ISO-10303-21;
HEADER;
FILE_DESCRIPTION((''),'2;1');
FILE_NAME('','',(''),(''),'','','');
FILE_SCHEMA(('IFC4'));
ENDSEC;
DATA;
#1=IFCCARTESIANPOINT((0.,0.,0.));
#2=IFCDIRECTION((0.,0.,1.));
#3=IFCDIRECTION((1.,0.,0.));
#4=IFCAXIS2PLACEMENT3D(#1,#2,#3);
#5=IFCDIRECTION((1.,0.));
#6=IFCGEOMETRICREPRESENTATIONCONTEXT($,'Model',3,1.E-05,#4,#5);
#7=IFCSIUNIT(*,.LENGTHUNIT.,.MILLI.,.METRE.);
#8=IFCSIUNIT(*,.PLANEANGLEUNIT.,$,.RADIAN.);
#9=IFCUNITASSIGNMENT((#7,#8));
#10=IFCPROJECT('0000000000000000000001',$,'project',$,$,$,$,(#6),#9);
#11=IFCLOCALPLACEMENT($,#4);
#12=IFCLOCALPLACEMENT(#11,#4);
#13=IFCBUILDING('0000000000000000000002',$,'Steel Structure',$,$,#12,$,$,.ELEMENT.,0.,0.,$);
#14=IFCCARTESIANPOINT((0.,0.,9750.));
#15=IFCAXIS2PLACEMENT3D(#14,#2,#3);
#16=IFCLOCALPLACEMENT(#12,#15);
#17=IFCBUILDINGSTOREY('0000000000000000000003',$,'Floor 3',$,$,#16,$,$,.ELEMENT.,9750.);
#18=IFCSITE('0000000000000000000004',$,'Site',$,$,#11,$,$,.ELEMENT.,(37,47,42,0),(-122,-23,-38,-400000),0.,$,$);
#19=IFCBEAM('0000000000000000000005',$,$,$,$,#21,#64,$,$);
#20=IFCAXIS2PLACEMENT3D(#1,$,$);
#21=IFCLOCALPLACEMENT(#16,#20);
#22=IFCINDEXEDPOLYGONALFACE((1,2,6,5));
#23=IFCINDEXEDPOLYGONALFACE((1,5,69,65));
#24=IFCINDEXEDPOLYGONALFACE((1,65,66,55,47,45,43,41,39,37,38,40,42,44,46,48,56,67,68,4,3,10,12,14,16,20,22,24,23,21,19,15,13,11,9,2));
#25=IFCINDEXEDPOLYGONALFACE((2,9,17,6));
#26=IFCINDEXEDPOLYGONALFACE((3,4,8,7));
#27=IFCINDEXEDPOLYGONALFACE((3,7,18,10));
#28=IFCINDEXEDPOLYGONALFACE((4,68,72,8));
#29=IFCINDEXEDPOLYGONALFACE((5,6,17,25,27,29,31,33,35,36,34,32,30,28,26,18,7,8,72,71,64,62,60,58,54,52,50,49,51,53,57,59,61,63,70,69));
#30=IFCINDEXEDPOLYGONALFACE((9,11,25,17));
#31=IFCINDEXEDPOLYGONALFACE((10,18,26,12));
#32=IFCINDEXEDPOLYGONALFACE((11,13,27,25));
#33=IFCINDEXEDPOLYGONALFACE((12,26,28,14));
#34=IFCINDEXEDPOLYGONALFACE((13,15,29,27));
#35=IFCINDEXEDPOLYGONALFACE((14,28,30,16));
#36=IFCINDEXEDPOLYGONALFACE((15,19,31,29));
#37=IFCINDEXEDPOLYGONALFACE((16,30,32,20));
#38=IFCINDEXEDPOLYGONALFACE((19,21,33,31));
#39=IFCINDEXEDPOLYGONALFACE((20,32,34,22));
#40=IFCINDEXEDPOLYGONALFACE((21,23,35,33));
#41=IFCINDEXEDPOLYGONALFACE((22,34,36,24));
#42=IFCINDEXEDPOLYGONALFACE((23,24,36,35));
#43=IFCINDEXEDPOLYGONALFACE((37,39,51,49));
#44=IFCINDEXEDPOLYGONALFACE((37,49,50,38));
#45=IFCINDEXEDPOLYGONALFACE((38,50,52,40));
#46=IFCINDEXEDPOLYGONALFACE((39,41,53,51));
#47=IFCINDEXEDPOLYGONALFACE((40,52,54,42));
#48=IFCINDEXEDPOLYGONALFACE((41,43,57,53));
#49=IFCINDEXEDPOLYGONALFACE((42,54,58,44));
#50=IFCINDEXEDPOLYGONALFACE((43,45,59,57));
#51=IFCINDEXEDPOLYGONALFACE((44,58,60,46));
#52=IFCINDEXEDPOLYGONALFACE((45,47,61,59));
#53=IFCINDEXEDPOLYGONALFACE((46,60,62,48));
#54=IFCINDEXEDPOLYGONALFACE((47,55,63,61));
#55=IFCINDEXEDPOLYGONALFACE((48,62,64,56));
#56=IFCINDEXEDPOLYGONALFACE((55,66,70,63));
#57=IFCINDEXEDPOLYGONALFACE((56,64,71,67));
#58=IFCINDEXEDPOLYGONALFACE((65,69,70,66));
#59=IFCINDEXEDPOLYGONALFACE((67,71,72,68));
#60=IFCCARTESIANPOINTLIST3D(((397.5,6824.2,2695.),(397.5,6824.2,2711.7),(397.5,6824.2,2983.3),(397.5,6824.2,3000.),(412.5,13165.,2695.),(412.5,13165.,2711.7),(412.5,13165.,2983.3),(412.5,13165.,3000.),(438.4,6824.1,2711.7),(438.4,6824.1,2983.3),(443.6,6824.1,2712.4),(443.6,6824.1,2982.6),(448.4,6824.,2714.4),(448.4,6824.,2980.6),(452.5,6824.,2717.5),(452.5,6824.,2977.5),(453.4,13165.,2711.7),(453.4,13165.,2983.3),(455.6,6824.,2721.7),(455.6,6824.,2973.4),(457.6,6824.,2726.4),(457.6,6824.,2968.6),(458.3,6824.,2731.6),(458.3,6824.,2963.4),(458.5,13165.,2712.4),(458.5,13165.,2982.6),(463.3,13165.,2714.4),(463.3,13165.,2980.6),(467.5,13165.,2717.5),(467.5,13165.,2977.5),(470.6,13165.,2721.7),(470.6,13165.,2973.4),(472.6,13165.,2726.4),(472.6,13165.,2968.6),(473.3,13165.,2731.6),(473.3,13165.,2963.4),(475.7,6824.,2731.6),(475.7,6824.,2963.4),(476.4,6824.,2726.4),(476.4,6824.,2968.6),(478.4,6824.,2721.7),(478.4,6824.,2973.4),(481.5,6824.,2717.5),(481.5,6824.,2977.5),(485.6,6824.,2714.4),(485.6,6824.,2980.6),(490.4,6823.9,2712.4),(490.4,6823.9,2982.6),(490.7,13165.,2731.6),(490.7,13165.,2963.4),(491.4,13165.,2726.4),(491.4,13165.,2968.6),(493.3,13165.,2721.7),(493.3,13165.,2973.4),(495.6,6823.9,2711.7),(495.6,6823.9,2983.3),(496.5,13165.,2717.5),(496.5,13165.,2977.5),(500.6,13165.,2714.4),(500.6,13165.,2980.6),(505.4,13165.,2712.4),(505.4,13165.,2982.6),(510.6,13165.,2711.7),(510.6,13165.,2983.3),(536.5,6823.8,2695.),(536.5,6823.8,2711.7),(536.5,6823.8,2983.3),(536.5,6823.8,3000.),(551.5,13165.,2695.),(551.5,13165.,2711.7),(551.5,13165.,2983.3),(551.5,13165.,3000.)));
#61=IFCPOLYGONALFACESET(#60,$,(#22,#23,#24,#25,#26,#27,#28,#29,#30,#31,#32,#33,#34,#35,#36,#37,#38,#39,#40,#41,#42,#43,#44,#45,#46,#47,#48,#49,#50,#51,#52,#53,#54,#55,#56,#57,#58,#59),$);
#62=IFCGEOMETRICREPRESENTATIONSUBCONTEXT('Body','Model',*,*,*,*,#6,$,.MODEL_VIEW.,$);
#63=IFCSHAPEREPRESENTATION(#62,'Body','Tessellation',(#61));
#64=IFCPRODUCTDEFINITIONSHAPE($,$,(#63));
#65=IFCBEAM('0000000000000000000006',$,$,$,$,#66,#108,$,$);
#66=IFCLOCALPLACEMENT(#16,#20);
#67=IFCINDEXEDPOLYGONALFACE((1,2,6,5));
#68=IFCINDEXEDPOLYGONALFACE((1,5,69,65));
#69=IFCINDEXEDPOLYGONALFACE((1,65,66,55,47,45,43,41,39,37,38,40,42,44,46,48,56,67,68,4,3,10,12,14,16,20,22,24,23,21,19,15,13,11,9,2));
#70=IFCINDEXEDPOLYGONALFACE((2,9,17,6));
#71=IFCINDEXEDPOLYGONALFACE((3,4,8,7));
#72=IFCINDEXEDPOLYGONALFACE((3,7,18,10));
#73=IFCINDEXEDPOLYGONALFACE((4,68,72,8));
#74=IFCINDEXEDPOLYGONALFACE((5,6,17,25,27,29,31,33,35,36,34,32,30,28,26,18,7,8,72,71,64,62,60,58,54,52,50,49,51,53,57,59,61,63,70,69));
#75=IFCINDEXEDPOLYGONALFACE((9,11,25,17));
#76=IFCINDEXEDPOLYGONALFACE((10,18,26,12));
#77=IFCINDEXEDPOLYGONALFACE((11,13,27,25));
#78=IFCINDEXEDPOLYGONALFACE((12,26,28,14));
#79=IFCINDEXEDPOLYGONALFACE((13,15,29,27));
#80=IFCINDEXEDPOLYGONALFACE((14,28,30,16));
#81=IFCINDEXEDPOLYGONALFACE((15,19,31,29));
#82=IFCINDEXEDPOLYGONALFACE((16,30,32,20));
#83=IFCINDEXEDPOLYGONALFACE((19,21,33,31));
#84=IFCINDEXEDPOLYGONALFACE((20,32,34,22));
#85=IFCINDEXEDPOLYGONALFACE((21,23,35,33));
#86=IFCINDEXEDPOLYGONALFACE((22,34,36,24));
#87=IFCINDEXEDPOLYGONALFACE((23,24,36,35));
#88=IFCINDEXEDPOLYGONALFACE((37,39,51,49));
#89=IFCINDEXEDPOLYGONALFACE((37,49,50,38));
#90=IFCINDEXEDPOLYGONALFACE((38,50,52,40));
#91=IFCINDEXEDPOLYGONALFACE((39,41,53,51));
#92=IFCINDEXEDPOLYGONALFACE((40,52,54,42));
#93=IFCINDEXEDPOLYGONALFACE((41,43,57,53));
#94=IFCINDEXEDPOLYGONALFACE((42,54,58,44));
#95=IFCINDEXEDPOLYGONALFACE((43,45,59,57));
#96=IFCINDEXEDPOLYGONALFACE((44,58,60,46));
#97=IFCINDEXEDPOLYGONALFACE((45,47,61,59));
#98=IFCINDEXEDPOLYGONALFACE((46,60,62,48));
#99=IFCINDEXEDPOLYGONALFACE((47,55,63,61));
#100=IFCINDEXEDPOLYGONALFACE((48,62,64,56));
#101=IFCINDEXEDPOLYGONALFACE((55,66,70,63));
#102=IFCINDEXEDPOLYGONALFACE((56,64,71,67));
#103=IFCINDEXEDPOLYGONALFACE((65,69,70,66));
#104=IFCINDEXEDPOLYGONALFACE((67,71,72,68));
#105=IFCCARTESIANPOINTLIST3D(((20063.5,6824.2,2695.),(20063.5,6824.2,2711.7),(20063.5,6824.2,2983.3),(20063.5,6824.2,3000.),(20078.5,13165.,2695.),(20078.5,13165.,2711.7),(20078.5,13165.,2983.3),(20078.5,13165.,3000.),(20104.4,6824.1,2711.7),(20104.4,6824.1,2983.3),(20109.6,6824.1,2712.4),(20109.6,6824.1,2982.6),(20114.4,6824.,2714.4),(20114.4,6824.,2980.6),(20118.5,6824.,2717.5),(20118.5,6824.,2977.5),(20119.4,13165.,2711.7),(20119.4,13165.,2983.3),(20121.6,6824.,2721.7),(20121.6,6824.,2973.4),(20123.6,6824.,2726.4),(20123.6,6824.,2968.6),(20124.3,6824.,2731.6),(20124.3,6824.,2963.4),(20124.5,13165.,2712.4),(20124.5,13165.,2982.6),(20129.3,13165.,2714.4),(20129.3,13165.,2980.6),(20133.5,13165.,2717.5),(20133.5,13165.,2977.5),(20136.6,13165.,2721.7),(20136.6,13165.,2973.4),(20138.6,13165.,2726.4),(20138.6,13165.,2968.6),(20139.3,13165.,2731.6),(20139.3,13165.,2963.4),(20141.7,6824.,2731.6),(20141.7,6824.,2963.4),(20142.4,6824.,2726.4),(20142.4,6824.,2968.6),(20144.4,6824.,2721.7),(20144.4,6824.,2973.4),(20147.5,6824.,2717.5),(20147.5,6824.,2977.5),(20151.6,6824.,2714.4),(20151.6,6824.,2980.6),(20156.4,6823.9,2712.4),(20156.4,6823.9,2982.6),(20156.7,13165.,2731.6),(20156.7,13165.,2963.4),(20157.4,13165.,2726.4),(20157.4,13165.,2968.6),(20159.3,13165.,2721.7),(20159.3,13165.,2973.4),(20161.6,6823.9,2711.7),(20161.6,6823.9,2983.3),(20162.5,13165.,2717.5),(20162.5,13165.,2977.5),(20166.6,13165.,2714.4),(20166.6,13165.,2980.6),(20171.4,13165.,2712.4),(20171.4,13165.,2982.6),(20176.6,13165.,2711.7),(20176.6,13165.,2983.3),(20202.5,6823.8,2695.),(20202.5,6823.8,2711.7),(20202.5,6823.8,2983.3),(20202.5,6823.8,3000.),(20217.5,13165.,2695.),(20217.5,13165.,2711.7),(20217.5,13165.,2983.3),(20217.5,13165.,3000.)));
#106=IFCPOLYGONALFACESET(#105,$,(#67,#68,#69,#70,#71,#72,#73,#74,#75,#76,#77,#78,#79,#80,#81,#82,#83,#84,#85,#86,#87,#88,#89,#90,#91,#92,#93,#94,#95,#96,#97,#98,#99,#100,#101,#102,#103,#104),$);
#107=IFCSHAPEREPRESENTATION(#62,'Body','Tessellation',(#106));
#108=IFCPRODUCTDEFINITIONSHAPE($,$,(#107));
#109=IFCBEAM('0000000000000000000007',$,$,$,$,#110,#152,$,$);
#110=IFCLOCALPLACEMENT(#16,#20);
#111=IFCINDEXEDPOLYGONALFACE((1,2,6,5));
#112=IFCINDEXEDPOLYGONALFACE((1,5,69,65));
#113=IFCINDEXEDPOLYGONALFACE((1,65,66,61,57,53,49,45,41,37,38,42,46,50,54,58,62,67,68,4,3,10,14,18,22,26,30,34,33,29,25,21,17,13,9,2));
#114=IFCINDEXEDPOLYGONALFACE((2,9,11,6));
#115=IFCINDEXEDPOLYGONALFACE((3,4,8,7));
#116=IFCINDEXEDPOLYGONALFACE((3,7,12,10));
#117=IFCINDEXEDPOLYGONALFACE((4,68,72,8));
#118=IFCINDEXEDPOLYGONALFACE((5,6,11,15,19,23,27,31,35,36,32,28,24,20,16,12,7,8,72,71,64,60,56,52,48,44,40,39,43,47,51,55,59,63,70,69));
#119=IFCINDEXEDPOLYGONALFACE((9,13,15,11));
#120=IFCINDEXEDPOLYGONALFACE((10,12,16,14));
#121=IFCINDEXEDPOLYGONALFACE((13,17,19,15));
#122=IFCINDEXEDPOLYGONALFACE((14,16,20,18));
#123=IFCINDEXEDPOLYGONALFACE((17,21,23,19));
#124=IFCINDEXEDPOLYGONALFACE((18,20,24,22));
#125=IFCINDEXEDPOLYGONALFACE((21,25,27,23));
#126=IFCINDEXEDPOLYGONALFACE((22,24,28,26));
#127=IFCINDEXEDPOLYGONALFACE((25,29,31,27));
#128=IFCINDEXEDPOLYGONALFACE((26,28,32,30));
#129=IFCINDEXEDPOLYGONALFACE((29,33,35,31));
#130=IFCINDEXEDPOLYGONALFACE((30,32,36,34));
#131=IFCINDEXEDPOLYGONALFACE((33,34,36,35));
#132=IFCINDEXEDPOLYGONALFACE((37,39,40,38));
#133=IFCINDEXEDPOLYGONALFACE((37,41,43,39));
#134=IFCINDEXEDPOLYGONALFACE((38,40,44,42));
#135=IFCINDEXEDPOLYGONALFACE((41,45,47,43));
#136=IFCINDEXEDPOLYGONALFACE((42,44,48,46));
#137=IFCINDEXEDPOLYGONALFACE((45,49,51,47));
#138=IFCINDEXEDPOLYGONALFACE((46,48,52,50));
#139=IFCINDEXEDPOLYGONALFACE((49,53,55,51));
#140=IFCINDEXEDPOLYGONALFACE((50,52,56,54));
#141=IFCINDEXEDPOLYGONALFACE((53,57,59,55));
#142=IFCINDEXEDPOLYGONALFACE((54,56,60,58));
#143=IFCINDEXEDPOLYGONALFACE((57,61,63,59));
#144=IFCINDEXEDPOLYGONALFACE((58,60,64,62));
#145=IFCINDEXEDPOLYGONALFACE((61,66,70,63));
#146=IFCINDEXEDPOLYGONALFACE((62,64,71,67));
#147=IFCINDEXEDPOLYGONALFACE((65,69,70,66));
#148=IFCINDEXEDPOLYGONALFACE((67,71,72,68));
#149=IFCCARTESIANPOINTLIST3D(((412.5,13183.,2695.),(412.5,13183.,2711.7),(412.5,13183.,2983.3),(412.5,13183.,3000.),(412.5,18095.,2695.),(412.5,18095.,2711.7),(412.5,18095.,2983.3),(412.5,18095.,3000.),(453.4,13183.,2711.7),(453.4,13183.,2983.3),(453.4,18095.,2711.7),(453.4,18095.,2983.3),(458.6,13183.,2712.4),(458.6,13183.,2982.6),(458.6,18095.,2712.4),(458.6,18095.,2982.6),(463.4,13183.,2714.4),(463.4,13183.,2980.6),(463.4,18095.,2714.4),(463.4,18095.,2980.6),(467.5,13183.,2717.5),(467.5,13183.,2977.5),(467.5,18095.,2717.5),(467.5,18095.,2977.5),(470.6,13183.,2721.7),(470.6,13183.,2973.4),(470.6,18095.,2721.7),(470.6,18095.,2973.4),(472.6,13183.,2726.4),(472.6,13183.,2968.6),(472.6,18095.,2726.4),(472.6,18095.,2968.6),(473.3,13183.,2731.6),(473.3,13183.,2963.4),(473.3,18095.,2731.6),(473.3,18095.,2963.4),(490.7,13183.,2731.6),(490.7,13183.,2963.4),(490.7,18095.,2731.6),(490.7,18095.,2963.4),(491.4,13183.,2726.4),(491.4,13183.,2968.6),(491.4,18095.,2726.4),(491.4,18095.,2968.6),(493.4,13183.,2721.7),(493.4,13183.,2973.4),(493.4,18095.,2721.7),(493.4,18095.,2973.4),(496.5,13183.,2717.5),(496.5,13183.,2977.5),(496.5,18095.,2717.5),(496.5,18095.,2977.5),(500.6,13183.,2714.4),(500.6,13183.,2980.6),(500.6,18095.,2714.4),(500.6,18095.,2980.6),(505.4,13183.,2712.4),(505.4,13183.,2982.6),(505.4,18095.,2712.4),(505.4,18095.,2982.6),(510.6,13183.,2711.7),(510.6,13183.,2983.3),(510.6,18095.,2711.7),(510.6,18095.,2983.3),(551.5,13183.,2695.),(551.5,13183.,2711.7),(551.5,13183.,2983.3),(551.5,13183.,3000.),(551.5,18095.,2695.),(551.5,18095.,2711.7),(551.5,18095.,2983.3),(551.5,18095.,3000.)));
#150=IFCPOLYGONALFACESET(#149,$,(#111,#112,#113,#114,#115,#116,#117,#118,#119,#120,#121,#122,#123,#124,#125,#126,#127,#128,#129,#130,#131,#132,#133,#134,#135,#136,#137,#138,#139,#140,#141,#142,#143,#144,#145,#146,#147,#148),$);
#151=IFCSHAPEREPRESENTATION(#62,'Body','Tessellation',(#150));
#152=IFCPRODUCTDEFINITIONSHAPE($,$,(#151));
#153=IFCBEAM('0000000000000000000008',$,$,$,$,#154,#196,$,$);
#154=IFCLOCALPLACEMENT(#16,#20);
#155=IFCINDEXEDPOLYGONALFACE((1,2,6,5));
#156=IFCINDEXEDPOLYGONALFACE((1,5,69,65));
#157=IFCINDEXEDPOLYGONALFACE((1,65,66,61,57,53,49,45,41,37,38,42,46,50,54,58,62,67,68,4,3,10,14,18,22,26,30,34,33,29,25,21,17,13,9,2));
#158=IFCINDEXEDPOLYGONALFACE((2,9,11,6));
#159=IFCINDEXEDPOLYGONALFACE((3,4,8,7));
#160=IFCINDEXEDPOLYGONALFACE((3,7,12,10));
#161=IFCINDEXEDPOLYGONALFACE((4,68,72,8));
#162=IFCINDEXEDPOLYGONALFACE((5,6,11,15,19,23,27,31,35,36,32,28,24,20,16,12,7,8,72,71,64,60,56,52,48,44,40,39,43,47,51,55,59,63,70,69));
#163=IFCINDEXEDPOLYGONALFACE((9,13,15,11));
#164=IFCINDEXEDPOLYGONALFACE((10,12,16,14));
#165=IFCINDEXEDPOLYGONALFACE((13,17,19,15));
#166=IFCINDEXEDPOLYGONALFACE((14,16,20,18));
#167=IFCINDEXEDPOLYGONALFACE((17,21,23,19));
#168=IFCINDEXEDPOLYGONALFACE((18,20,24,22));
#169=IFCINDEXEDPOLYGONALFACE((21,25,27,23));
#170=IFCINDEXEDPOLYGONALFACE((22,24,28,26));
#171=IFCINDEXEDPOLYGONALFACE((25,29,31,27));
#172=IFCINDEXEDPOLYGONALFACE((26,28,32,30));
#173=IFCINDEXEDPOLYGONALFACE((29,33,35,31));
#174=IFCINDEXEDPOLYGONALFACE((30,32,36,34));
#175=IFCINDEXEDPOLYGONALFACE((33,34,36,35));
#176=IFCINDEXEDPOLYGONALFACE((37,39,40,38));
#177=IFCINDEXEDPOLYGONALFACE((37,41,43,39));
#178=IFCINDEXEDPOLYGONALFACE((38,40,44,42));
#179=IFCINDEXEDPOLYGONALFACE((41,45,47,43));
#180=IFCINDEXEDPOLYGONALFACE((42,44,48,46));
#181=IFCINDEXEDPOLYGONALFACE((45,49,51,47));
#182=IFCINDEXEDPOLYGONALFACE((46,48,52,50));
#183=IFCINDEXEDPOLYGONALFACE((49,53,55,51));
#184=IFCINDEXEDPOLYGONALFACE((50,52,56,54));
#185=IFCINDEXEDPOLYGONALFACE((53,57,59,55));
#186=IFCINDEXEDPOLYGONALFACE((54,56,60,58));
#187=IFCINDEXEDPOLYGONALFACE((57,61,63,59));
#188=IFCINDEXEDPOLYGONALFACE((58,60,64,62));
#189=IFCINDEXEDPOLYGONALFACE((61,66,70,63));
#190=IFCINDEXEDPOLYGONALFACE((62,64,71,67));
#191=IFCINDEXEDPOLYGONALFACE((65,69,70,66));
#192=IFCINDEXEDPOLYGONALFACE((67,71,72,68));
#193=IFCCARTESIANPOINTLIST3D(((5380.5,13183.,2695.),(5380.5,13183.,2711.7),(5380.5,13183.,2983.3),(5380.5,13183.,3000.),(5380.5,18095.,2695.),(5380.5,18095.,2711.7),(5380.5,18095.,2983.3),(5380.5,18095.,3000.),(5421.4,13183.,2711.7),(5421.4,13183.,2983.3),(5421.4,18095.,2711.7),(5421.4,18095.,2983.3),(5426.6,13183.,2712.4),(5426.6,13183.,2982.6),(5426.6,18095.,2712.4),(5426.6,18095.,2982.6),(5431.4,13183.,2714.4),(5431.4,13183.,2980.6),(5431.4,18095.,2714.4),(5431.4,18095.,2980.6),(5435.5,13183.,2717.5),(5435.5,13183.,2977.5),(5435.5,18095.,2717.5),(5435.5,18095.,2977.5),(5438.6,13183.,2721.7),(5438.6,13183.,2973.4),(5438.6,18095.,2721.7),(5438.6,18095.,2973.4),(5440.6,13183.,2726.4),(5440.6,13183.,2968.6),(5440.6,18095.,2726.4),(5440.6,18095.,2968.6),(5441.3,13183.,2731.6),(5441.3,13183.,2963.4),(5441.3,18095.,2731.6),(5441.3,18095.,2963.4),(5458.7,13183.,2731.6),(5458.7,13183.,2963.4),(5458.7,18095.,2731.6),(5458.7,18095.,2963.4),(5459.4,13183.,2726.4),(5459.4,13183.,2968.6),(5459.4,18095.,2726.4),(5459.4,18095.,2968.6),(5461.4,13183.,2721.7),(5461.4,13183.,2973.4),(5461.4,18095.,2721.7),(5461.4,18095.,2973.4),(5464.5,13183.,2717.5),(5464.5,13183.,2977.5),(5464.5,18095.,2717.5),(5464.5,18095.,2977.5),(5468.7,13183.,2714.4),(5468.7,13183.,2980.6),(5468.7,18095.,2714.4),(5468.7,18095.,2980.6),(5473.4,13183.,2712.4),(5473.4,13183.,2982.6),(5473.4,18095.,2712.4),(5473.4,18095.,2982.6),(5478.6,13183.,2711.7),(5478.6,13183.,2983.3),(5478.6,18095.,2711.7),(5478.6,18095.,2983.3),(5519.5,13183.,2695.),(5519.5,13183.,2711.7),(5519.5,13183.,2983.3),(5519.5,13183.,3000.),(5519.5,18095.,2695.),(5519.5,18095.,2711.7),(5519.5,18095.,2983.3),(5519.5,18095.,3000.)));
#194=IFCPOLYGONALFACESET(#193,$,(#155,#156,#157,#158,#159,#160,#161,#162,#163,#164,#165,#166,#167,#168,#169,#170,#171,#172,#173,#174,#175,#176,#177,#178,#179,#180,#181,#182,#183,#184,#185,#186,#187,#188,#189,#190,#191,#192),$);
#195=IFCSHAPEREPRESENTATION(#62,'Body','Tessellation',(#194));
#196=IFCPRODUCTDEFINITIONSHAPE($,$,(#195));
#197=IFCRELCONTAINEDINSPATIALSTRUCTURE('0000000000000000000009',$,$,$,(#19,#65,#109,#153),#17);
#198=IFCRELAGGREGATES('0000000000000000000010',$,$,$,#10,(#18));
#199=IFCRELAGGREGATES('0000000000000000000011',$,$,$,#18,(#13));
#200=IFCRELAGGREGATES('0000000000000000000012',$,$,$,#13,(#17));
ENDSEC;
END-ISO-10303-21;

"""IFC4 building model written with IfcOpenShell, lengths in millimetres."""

from ifc_helpers import new_model, si_unit, direction, frame, origin_with_axes, origin_2d_with_axis, place, context, subcontext, project, spatial, polyline, i_section, extrude, clip, bounded_halfspace, element, save


model = new_model("IFC4")

# Units and contexts
model_context = context("Model", 3, precision=1e-05, world=origin_with_axes(), true_north=direction((1.0, 0.0)))
body_context = subcontext(model_context, "Body", "Model", "MODEL_VIEW")
ifc_project = project(units=[si_unit("LENGTHUNIT", "METRE", prefix="MILLI"), si_unit("PLANEANGLEUNIT", "RADIAN")], contexts=[model_context])

# Site, building, storey
site_placement = place(None, origin_with_axes())
site = spatial("IfcSite", under=ifc_project, at=site_placement, Name="Site", CompositionType="ELEMENT", RefLatitude=(37, 47, 42, 0), RefLongitude=(-122, -23, -38, -400000), RefElevation=0.0)
building_placement = place(site_placement, origin_with_axes())
building = spatial("IfcBuilding", under=site, at=building_placement, Name="Steel Structure", CompositionType="ELEMENT", ElevationOfRefHeight=0.0, ElevationOfTerrain=0.0)
storey_placement = place(building_placement, frame((0.0, 0.0, 9750.0), z_axis=(0.0, 0.0, 1.0), x_axis=(1.0, 0.0, 0.0)))
storey = spatial("IfcBuildingStorey", under=building, at=storey_placement, Name="Floor 3", CompositionType="ELEMENT", Elevation=9750.0)

# Beams
beam_1_placement = place(storey_placement, frame((482.0, 13165.2, 2695.0), z_axis=(-0.002362, -0.999997, 0.0), x_axis=(0.999997, -0.002362, 0.0)))
element("IfcBeam", 1, at=beam_1_placement, inside=storey, context=body_context, shape_type="Clipping", body=[
    clip(extrude(i_section(OverallWidth=139.0, OverallDepth=305.0, WebThickness=17.4, FlangeThickness=16.7, FilletRadius=19.9, at=origin_2d_with_axis()), frame((0.0, 152.5, 0.0), z_axis=(0.0, 0.0, 1.0), x_axis=(1.0, 0.0, 0.0)), (0.0, 0.0, 1.0), 6341.2), bounded_halfspace(frame((-482.0, -12445.0, 1.3), z_axis=(-0.002362, 0.0, -0.999997), x_axis=(-0.999997, 0.0, 0.002362)), False, frame((0.0, 152.5, 0.0), z_axis=(0.0, 0.0, 1.0), x_axis=(1.0, 0.0, 0.0)), polyline([(69.5, 152.5), (69.5, 135.8), (28.6, 135.8), (8.7, 115.9), (8.7, -115.9), (28.6, -135.8), (69.5, -135.8), (69.5, -152.5), (-69.5, -152.5), (-69.5, -135.8), (-28.6, -135.8), (-8.7, -115.9), (-8.7, 115.9), (-28.6, 135.8), (-69.5, 135.8), (-69.5, 152.5), (69.5, 152.5)]))),
])
beam_2_placement = place(storey_placement, frame((20148.0, 13165.2, 2695.0), z_axis=(-0.002362, -0.999997, 0.0), x_axis=(0.999997, -0.002362, 0.0)))
element("IfcBeam", 2, at=beam_2_placement, inside=storey, context=body_context, shape_type="Clipping", body=[
    clip(extrude(i_section(OverallWidth=139.0, OverallDepth=305.0, WebThickness=17.4, FlangeThickness=16.7, FilletRadius=19.9, at=origin_2d_with_axis()), frame((0.0, 152.5, 0.0), z_axis=(0.0, 0.0, 1.0), x_axis=(1.0, 0.0, 0.0)), (0.0, 0.0, 1.0), 6341.2), bounded_halfspace(frame((-20147.9, -12445.0, 47.8), z_axis=(-0.002362, 0.0, -0.999997), x_axis=(-0.999997, 0.0, 0.002362)), False, frame((0.0, 152.5, 0.0), z_axis=(0.0, 0.0, 1.0), x_axis=(1.0, 0.0, 0.0)), polyline([(69.5, 152.5), (69.5, 135.8), (28.6, 135.8), (8.7, 115.9), (8.7, -115.9), (28.6, -135.8), (69.5, -135.8), (69.5, -152.5), (-69.5, -152.5), (-69.5, -135.8), (-28.6, -135.8), (-8.7, -115.9), (-8.7, 115.9), (-28.6, 135.8), (-69.5, 135.8), (-69.5, 152.5), (69.5, 152.5)]))),
])
for number, where, z_axis, x_axis in (
    (3, (482.0, 13183.0, 2695.0), (0.0, 1.0, 0.0), (-1.0, 0.0, 0.0)),
    (4, (5450.0, 18095.0, 2695.0), (0.0, -1.0, 0.0), (1.0, 0.0, 0.0)),
):
    element("IfcBeam", number, at=place(storey_placement, frame(where, z_axis=z_axis, x_axis=x_axis)), inside=storey, context=body_context, shape_type="SweptSolid", body=[
        extrude(i_section(OverallWidth=139.0, OverallDepth=305.0, WebThickness=17.4, FlangeThickness=16.7, FilletRadius=19.9, at=origin_2d_with_axis()), frame((0.0, 152.5, 0.0), z_axis=(0.0, 0.0, 1.0), x_axis=(1.0, 0.0, 0.0)), (0.0, 0.0, 1.0), 4912.0),
    ])

save(model, "model.ifc")
